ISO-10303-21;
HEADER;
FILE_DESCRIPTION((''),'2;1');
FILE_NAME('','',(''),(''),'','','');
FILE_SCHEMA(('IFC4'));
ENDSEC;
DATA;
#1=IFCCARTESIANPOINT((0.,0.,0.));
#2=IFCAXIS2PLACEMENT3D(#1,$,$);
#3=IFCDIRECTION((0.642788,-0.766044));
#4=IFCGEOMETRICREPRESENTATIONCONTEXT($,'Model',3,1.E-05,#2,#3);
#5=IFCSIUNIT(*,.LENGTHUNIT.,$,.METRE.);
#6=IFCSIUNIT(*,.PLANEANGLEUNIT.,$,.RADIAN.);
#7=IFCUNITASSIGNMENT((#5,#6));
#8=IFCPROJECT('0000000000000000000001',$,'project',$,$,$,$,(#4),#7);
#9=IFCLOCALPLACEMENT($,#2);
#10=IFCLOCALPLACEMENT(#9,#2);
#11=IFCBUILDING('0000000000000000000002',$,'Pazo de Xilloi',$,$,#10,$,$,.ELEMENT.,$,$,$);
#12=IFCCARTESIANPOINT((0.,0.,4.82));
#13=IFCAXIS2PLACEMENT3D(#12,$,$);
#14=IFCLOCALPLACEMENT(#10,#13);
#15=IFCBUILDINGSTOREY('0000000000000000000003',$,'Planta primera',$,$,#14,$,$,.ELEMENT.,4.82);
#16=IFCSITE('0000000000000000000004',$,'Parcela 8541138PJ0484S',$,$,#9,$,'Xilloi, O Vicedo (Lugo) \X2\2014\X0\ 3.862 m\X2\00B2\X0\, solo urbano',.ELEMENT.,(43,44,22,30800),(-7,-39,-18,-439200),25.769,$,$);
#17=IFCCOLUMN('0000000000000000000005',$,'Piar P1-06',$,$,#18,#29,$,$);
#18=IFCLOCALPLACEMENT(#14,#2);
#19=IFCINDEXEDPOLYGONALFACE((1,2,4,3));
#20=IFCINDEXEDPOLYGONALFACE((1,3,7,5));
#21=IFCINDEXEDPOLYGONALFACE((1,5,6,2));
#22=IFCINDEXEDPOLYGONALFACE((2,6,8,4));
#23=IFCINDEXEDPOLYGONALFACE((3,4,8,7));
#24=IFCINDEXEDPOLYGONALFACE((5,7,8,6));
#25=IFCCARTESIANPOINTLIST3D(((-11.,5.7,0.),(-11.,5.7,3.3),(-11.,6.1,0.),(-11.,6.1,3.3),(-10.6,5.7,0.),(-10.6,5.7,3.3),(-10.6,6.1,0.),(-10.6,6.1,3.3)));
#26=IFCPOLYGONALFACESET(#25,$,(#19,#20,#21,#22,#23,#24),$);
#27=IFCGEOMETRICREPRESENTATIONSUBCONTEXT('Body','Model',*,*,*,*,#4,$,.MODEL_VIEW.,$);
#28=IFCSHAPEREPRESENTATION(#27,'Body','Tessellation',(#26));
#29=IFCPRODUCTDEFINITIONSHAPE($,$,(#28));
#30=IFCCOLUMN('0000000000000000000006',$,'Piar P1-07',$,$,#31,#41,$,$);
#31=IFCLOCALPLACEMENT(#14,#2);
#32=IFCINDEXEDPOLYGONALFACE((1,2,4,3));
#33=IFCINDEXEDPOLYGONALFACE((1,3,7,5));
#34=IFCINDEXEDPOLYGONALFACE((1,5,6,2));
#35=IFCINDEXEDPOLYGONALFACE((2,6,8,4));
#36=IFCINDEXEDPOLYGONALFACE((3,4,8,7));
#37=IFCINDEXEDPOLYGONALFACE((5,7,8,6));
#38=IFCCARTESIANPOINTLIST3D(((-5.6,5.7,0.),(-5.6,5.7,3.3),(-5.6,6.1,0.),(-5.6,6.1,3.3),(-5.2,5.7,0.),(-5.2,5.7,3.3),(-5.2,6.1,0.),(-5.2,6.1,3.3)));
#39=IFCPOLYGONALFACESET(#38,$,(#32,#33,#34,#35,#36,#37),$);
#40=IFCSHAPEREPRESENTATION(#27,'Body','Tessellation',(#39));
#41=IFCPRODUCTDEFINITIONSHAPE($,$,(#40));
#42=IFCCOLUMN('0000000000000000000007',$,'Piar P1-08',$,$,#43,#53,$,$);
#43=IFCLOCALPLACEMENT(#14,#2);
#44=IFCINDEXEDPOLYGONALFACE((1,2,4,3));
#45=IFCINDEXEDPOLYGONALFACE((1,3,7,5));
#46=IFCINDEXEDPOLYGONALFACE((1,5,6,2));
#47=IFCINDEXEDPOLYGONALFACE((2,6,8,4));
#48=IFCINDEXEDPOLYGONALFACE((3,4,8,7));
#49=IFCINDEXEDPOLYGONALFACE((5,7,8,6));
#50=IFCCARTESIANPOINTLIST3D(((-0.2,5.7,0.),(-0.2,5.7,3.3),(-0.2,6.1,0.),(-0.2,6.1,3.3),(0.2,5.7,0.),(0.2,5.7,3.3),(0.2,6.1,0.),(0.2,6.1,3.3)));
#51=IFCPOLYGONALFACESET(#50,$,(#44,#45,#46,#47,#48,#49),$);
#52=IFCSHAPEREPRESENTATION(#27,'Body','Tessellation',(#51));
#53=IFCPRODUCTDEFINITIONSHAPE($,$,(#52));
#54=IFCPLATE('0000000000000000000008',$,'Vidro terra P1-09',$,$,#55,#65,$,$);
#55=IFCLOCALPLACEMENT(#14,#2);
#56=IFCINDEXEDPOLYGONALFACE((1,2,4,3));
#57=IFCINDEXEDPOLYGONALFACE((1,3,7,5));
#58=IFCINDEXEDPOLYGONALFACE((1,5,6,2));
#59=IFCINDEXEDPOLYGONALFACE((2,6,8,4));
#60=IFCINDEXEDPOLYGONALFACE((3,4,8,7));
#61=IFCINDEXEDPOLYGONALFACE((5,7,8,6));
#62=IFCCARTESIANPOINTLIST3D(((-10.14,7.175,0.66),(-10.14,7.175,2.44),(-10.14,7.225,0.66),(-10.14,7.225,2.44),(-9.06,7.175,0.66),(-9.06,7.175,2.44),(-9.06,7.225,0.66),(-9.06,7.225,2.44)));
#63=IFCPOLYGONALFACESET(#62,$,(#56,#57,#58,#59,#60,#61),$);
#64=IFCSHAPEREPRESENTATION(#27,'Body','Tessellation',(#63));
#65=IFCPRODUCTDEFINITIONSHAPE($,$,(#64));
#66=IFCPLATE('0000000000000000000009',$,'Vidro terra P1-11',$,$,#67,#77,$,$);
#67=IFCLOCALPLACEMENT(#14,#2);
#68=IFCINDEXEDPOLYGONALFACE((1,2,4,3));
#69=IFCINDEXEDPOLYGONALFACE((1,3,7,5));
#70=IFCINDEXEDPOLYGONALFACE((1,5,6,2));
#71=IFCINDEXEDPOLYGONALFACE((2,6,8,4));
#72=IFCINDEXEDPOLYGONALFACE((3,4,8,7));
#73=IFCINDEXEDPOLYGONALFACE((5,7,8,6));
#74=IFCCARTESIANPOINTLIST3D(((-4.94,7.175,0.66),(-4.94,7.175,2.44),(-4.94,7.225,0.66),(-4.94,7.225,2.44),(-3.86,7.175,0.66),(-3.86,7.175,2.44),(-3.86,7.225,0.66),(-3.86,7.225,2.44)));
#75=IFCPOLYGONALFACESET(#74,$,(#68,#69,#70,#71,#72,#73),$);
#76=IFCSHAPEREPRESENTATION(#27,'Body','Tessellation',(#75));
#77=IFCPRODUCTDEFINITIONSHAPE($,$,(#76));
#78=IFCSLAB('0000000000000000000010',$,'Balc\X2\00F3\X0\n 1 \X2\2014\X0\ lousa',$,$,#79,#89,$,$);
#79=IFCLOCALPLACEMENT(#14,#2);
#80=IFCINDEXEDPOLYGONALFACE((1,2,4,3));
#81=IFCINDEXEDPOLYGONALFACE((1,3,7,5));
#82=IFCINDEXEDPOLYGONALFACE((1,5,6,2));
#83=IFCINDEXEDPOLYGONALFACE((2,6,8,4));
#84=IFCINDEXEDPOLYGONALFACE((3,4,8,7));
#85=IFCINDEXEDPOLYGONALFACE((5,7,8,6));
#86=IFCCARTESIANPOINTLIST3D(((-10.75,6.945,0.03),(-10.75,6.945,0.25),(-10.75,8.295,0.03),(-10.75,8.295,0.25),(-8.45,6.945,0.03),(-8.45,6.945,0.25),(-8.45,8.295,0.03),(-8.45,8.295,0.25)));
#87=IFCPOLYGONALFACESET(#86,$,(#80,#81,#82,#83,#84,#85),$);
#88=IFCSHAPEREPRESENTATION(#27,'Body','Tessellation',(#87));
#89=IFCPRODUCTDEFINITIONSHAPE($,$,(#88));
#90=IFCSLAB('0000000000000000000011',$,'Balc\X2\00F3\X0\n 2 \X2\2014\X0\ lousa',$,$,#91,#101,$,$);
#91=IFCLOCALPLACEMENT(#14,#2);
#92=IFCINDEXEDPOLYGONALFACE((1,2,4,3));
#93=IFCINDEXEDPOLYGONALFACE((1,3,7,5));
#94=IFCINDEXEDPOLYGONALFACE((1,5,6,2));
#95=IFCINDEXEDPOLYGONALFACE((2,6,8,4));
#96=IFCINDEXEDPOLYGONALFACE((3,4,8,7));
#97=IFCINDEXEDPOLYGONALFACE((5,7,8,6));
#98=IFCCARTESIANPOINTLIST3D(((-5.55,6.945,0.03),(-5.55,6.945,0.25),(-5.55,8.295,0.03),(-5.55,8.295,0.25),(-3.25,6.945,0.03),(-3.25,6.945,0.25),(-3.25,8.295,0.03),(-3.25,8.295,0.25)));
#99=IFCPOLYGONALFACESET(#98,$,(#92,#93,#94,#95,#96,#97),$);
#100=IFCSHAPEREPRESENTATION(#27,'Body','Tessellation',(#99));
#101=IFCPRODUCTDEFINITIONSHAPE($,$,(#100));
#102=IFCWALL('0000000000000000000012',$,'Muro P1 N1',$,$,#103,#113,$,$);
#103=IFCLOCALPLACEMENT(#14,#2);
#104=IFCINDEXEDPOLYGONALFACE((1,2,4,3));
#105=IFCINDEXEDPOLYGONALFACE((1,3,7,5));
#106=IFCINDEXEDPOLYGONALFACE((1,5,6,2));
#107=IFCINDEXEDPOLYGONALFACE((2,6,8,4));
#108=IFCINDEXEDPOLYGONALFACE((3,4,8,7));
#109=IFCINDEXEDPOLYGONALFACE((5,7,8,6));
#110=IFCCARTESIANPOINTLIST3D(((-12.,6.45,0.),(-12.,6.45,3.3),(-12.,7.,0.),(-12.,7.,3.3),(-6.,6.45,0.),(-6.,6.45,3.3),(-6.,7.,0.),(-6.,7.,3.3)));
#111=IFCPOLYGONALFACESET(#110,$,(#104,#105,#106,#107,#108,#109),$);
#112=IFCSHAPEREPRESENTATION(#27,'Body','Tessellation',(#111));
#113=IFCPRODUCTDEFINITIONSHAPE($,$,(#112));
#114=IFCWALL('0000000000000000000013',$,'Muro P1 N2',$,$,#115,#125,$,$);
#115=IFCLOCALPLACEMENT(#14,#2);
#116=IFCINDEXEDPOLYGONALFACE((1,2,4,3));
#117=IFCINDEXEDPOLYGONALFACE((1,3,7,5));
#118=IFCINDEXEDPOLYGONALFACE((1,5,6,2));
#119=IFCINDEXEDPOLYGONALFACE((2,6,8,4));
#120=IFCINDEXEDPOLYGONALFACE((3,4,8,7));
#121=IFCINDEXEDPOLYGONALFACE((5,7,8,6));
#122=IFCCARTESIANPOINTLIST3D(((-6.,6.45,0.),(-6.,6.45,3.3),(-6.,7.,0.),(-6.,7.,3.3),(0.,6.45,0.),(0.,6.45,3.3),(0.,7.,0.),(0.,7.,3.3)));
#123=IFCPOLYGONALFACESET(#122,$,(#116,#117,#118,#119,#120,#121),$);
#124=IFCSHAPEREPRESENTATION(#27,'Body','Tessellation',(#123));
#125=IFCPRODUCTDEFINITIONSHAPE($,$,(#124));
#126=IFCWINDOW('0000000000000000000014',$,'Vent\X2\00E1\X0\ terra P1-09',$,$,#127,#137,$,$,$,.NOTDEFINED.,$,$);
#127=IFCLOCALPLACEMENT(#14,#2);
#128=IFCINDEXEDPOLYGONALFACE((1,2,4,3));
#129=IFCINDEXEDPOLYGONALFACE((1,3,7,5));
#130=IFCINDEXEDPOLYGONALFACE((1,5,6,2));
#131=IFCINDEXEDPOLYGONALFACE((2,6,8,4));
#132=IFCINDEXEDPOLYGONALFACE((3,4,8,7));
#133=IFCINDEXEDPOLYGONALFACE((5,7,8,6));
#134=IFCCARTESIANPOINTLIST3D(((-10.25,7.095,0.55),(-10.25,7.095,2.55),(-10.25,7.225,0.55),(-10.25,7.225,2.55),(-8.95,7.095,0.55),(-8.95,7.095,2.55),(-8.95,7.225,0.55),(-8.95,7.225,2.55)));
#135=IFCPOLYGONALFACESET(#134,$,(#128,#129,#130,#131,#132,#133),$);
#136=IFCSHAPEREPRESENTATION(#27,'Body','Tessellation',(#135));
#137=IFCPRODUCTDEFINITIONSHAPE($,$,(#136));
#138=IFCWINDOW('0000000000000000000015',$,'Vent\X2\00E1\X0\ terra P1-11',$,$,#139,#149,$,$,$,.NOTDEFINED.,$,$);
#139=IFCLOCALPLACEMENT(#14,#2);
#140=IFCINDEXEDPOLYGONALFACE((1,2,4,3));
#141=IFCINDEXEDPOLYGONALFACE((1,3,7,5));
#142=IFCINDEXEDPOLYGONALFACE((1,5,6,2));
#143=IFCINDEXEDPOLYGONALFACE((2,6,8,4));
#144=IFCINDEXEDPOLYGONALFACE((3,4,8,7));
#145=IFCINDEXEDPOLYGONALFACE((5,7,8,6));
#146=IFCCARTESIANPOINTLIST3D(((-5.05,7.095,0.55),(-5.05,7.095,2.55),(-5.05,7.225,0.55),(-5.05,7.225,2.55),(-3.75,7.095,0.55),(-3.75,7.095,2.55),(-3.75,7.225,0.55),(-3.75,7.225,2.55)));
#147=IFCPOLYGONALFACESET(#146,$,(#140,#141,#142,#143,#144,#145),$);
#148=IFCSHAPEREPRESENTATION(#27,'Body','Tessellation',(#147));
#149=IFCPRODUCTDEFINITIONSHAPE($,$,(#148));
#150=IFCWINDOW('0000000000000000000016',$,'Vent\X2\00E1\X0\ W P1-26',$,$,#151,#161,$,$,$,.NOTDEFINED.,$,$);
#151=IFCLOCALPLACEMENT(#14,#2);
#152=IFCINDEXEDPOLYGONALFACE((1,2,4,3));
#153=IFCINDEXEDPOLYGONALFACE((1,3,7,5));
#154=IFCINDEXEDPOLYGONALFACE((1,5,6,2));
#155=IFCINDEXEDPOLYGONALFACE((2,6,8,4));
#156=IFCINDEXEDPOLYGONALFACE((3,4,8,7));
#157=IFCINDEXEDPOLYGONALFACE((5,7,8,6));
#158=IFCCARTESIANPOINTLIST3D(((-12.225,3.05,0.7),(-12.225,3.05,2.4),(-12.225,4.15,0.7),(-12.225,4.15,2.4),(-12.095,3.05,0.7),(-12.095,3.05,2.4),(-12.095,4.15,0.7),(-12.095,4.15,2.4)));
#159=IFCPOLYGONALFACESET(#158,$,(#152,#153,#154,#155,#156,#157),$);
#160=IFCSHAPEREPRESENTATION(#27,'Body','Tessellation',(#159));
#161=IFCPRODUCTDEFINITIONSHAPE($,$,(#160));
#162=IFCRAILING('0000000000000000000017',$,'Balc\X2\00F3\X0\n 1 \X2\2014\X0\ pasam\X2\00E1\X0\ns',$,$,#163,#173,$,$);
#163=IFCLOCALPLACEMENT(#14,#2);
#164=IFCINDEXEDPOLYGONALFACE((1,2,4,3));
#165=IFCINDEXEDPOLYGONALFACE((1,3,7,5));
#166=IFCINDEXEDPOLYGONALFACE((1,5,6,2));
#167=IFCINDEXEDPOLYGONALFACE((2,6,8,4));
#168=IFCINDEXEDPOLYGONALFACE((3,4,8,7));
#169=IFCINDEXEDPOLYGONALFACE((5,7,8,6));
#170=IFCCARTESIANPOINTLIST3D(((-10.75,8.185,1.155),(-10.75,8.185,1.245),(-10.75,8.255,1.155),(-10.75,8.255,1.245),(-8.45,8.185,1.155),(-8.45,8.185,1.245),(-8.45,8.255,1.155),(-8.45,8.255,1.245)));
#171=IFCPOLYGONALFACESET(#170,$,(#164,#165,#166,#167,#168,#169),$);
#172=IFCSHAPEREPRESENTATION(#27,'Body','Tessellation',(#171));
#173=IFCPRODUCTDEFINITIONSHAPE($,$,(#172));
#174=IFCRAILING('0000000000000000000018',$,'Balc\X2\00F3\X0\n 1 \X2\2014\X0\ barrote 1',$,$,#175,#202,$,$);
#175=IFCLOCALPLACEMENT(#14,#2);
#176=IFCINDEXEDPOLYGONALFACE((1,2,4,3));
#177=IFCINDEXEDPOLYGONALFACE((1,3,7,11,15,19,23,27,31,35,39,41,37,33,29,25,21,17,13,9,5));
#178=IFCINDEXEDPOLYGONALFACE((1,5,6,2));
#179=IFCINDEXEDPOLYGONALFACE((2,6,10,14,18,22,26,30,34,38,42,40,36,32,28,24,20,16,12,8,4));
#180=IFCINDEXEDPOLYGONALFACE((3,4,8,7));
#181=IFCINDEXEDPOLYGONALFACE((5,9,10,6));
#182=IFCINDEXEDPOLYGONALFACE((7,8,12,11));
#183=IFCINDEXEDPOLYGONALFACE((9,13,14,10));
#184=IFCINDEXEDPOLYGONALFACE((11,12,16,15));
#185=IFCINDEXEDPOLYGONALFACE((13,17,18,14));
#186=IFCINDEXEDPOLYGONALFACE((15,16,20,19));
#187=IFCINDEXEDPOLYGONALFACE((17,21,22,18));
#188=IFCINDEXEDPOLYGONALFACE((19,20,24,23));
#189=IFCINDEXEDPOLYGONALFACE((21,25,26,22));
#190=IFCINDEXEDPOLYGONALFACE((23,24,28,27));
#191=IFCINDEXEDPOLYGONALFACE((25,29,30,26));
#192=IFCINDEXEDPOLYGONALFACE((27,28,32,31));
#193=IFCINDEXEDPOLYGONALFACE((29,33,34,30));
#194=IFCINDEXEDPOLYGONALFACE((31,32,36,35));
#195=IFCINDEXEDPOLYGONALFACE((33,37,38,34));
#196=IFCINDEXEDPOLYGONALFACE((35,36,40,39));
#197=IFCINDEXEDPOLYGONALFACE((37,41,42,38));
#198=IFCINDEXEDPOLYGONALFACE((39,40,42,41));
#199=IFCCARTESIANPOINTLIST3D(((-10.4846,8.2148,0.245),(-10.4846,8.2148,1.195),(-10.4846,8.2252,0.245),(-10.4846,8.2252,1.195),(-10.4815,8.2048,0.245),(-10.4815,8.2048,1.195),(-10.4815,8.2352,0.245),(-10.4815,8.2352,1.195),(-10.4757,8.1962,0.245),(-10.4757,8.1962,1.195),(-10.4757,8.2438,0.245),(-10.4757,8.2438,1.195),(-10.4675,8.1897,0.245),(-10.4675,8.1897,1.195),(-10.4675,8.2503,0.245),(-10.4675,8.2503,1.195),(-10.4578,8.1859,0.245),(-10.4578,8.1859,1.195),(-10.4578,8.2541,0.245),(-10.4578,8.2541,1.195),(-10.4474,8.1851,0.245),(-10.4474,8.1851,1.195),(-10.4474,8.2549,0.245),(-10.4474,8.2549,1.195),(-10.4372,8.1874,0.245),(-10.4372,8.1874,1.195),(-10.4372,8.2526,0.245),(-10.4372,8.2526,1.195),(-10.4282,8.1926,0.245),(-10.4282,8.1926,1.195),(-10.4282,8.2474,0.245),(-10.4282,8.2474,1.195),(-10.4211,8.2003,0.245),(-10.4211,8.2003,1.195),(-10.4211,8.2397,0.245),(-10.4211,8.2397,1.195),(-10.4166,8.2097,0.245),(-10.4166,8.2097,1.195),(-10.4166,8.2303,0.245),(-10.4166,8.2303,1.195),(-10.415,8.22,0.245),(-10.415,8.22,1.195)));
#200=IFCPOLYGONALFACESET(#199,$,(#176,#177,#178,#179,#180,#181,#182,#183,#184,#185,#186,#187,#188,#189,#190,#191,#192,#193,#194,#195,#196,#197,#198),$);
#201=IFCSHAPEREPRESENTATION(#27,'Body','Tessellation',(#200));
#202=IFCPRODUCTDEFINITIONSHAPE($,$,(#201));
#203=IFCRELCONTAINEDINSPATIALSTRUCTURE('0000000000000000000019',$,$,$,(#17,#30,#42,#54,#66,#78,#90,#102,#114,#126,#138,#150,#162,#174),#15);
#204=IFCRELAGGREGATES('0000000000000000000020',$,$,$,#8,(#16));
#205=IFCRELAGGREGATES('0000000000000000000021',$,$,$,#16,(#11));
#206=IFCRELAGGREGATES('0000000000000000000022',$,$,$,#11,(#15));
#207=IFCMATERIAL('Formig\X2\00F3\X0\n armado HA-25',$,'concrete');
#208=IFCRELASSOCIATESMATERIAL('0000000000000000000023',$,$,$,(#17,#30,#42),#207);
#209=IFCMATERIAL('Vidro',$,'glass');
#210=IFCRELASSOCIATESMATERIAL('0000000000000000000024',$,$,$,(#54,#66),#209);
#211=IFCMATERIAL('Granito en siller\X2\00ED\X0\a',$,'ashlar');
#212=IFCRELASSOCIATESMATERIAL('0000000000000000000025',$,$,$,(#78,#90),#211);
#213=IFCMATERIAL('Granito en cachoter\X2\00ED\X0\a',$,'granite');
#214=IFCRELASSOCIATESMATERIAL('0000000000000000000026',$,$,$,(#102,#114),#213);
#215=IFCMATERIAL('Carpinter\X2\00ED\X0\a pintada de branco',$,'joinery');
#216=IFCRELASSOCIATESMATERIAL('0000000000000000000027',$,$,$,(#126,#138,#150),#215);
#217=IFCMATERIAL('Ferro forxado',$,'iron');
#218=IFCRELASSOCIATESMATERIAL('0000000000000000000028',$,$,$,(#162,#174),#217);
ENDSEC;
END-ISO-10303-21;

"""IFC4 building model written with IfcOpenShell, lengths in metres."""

from ifc_helpers import new_model, si_unit, direction, frame, origin, origin_2d, place, context, subcontext, project, spatial, rectangle, circle, extrude, material, element, save


model = new_model("IFC4")

# Units and contexts
model_context = context("Model", 3, precision=1e-05, world=origin(), true_north=direction((0.642788, -0.766044)))
body_context = subcontext(model_context, "Body", "Model", "MODEL_VIEW")
ifc_project = project(units=[si_unit("LENGTHUNIT", "METRE"), si_unit("PLANEANGLEUNIT", "RADIAN")], contexts=[model_context])

# Site, building, storey
site_placement = place(None, origin())
site = spatial("IfcSite", under=ifc_project, at=site_placement, Name="Parcela 8541138PJ0484S", LongName="Xilloi, O Vicedo (Lugo) — 3.862 m², solo urbano", CompositionType="ELEMENT", RefLatitude=(43, 44, 22, 30800), RefLongitude=(-7, -39, -18, -439200), RefElevation=25.769)
building_placement = place(site_placement, origin())
building = spatial("IfcBuilding", under=site, at=building_placement, Name="Pazo de Xilloi", CompositionType="ELEMENT")
storey_placement = place(building_placement, frame((0.0, 0.0, 4.82)))
storey = spatial("IfcBuildingStorey", under=building, at=storey_placement, Name="Planta primera", CompositionType="ELEMENT", Elevation=4.82)

# Columns
ifc_material_1 = material(Name="Formigón armado HA-25", Category="concrete")
for number, where, name in (
    (1, (-10.8, 5.9, 1.65), "Piar P1-06"),
    (2, (-5.4, 5.9, 1.65), "Piar P1-07"),
    (3, (0.0, 5.9, 1.65), "Piar P1-08"),
):
    element("IfcColumn", number, at=place(storey_placement, frame(where)), inside=storey, material=ifc_material_1, Name=name, context=body_context, shape_type="SweptSolid", body=[
        extrude(rectangle(XDim=0.4, YDim=0.4, at=origin_2d()), frame((0.0, 0.0, -1.65)), (0.0, 0.0, 1.0), 3.3),
    ])

# Plates
ifc_material_2 = material(Name="Vidro", Category="glass")
for number, where, name in (
    (4, (-9.6, 7.2, 1.55), "Vidro terra P1-09"),
    (5, (-4.4, 7.2, 1.55), "Vidro terra P1-11"),
):
    element("IfcPlate", number, at=place(storey_placement, frame(where)), inside=storey, material=ifc_material_2, Name=name, context=body_context, shape_type="SweptSolid", body=[
        extrude(rectangle(XDim=1.08, YDim=0.05, at=origin_2d()), frame((0.0, 0.0, -0.89)), (0.0, 0.0, 1.0), 1.78),
    ])

# Slabs
ifc_material_3 = material(Name="Granito en sillería", Category="ashlar")
for number, where, name in (
    (6, (-9.6, 7.62, 0.14), "Balcón 1 — lousa"),
    (7, (-4.4, 7.62, 0.14), "Balcón 2 — lousa"),
):
    element("IfcSlab", number, at=place(storey_placement, frame(where)), inside=storey, material=ifc_material_3, Name=name, context=body_context, shape_type="SweptSolid", body=[
        extrude(rectangle(XDim=2.3, YDim=1.35, at=origin_2d()), frame((0.0, 0.0, -0.11)), (0.0, 0.0, 1.0), 0.22),
    ])

# Walls
ifc_material_4 = material(Name="Granito en cachotería", Category="granite")
for number, where, name in (
    (8, (-9.0, 6.725, 1.65), "Muro P1 N1"),
    (9, (-3.0, 6.725, 1.65), "Muro P1 N2"),
):
    element("IfcWall", number, at=place(storey_placement, frame(where)), inside=storey, material=ifc_material_4, Name=name, context=body_context, shape_type="SweptSolid", body=[
        extrude(rectangle(XDim=6.0, YDim=0.55, at=origin_2d()), frame((0.0, 0.0, -1.65)), (0.0, 0.0, 1.0), 3.3),
    ])

# Windows
ifc_material_5 = material(Name="Carpintería pintada de branco", Category="joinery")
for number, where, name in (
    (10, (-9.6, 7.16, 1.55), "Ventá terra P1-09"),
    (11, (-4.4, 7.16, 1.55), "Ventá terra P1-11"),
):
    element("IfcWindow", number, at=place(storey_placement, frame(where)), inside=storey, material=ifc_material_5, Name=name, PredefinedType="NOTDEFINED", context=body_context, shape_type="SweptSolid", body=[
        extrude(rectangle(XDim=1.3, YDim=0.13, at=origin_2d()), frame((0.0, 0.0, -1.0)), (0.0, 0.0, 1.0), 2.0),
    ])
window_placement = place(storey_placement, frame((-12.16, 3.6, 1.55)))
element("IfcWindow", 12, at=window_placement, inside=storey, material=ifc_material_5, Name="Ventá W P1-26", PredefinedType="NOTDEFINED", context=body_context, shape_type="SweptSolid", body=[
    extrude(rectangle(XDim=0.13, YDim=1.1, at=origin_2d()), frame((0.0, 0.0, -0.85)), (0.0, 0.0, 1.0), 1.7),
])

# Railings
ifc_material_6 = material(Name="Ferro forxado", Category="iron")
railing_1_placement = place(storey_placement, frame((-9.6, 8.22, 1.2)))
element("IfcRailing", 13, at=railing_1_placement, inside=storey, material=ifc_material_6, Name="Balcón 1 — pasamáns", context=body_context, shape_type="SweptSolid", body=[
    extrude(rectangle(XDim=2.3, YDim=0.07, at=origin_2d()), frame((0.0, 0.0, -0.045)), (0.0, 0.0, 1.0), 0.09),
])
for number, where, name in (
    (14, (-10.45, 8.22, 0.72), "Balcón 1 — barrote 1"),
):
    element("IfcRailing", number, at=place(storey_placement, frame(where)), inside=storey, material=ifc_material_6, Name=name, context=body_context, shape_type="SweptSolid", body=[
        extrude(circle(Radius=0.035, at=origin_2d()), frame((0.0, 0.0, -0.475)), (0.0, 0.0, 1.0), 0.95),
    ])

save(model, "model.ifc")
